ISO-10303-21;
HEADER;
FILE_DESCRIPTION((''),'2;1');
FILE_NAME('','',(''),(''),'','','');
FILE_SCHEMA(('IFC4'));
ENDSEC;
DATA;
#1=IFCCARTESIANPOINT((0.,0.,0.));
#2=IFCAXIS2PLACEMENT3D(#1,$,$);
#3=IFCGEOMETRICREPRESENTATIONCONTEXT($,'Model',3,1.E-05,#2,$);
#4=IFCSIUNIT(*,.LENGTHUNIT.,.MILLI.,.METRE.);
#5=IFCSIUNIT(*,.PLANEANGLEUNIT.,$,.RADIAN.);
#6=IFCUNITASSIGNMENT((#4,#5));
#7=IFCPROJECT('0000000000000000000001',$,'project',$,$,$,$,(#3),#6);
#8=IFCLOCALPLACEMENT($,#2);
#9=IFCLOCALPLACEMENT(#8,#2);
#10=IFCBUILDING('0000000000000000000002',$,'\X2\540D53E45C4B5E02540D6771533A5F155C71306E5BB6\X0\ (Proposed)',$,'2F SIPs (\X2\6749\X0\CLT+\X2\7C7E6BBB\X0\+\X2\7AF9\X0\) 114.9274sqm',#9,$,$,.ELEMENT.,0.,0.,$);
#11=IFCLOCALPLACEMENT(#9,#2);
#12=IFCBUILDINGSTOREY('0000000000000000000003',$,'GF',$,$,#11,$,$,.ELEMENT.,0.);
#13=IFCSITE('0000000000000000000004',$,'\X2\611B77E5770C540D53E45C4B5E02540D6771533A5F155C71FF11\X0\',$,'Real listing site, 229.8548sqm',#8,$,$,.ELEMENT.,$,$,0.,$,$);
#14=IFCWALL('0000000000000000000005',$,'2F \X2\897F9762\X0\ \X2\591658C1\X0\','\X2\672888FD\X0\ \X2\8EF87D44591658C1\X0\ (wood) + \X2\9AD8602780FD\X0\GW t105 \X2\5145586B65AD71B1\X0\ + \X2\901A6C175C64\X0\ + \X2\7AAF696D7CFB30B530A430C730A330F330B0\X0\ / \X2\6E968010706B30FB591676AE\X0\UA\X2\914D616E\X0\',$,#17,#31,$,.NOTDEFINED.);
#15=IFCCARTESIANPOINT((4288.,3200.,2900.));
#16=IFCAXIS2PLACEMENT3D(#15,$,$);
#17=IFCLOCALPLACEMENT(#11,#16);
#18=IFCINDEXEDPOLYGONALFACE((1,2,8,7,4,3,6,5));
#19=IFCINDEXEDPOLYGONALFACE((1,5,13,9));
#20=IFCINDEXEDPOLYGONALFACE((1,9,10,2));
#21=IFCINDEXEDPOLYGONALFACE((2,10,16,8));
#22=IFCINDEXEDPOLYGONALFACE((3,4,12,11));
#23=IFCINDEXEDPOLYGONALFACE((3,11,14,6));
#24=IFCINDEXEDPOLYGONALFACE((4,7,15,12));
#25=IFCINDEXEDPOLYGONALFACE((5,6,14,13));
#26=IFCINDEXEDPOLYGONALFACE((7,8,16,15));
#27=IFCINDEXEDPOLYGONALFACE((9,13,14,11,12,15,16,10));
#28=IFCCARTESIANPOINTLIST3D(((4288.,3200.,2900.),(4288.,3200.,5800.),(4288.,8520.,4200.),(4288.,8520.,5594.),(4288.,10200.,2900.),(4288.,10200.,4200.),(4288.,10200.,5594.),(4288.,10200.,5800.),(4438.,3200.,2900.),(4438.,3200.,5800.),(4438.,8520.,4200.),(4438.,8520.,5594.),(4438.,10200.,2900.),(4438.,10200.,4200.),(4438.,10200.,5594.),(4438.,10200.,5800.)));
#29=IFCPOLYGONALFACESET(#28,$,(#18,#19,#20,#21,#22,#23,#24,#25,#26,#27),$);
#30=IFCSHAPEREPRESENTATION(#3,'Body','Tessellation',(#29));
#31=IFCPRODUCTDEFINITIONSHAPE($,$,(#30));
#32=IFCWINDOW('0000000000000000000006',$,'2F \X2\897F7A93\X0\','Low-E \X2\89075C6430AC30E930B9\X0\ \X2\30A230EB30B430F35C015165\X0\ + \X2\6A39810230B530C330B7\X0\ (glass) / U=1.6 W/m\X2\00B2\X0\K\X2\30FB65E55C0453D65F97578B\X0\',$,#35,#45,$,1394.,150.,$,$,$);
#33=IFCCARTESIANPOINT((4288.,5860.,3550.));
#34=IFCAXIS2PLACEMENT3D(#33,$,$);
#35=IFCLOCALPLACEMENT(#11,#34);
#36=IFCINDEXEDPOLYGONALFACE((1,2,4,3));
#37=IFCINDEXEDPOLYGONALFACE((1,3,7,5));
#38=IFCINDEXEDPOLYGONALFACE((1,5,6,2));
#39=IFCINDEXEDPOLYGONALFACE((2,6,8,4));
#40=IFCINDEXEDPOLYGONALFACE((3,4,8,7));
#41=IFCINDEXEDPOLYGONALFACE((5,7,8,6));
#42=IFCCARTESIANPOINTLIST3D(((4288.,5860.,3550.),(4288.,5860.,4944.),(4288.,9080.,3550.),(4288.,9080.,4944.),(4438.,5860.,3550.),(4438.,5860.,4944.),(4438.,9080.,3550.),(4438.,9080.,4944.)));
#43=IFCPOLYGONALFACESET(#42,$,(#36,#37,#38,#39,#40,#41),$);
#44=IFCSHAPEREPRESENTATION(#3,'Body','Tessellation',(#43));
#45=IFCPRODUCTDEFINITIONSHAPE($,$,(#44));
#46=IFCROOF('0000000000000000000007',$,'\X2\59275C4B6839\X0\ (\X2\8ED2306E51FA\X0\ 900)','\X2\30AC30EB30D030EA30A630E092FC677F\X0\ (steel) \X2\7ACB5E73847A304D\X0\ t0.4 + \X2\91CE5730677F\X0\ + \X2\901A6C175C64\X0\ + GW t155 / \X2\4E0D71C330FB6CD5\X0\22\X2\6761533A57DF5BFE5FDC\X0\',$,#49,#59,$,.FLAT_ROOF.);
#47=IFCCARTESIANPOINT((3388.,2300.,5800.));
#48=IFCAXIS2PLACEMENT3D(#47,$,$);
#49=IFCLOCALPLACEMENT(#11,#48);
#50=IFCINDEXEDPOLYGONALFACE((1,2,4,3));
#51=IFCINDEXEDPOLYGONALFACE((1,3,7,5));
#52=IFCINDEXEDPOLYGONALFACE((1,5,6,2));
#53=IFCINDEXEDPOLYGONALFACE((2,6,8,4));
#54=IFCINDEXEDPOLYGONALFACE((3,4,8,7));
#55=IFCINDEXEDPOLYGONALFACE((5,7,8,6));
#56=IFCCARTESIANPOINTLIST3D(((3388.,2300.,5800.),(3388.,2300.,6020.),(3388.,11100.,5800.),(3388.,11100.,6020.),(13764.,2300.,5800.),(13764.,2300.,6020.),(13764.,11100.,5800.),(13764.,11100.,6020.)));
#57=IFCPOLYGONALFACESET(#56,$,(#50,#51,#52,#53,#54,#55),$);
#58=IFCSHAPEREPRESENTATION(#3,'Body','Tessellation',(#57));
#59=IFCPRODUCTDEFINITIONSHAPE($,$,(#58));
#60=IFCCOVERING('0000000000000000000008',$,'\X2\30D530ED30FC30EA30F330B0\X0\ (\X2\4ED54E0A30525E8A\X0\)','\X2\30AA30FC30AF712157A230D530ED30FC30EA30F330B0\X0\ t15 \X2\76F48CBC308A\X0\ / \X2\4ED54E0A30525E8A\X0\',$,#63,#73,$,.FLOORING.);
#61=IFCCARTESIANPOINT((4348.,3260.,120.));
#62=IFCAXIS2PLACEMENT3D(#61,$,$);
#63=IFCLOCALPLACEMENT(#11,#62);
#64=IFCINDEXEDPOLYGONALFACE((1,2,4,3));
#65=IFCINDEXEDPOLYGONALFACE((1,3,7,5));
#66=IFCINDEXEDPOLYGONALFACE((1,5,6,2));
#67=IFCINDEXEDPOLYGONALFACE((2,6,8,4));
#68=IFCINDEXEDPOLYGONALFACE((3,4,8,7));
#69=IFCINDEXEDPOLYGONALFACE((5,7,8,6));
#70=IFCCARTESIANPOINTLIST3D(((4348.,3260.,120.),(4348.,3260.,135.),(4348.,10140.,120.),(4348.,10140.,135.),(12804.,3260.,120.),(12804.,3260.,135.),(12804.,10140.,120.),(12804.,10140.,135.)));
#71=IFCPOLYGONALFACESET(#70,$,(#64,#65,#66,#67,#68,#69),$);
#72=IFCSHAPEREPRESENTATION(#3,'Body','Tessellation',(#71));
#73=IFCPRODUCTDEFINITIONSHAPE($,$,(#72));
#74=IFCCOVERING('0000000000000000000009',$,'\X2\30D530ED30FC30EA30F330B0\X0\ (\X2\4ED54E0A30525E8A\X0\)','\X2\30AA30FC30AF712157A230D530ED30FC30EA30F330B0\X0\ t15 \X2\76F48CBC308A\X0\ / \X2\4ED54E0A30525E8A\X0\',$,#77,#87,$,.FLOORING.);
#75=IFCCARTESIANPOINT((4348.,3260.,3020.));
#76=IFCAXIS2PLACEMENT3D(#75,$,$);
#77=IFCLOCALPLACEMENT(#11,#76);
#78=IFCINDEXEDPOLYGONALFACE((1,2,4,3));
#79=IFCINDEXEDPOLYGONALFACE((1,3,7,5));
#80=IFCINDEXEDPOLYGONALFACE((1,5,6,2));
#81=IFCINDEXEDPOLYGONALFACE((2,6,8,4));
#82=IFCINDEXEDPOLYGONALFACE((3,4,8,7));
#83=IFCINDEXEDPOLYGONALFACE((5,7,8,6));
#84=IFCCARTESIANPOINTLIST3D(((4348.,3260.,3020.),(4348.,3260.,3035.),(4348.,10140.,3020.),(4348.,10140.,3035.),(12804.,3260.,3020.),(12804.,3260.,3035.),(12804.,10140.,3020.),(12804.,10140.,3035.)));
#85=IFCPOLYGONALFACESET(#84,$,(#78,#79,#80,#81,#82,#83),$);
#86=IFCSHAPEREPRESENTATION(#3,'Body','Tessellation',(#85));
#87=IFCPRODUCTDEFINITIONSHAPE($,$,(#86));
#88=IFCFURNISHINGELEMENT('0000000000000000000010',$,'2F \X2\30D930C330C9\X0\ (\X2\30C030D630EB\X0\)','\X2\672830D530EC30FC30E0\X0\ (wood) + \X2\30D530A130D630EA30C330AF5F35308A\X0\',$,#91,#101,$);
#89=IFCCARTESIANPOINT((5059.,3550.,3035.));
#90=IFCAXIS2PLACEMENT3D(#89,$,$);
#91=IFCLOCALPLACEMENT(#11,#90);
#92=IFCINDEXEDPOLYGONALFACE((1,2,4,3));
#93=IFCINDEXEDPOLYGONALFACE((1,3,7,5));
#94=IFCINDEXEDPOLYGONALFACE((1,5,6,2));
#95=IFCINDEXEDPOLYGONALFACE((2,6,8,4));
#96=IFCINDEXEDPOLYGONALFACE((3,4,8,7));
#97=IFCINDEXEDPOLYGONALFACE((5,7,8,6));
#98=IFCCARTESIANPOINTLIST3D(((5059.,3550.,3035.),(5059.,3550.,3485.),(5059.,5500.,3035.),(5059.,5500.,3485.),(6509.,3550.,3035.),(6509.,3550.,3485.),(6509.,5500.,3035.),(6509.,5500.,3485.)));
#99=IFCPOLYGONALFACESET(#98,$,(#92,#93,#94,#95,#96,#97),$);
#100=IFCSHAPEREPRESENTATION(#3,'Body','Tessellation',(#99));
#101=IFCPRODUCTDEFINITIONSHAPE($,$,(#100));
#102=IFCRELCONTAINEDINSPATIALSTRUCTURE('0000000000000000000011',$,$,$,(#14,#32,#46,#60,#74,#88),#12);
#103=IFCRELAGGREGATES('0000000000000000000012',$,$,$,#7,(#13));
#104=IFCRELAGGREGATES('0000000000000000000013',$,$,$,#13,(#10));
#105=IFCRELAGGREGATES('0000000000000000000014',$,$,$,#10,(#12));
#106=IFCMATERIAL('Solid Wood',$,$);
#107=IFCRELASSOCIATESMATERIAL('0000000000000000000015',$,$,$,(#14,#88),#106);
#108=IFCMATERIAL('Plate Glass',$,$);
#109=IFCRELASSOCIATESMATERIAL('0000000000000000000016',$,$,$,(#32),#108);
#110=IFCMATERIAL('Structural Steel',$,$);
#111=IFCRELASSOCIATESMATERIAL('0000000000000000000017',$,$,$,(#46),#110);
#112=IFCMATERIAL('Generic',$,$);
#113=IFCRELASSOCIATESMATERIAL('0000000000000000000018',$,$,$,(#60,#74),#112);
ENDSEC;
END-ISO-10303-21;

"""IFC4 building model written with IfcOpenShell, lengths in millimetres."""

from ifc_helpers import new_model, si_unit, frame, frame_2d, origin, place, context, project, spatial, rectangle, extrude, material, element, fill, save


model = new_model("IFC4")

# Units and contexts
model_context = context("Model", 3, precision=1e-05, world=origin())
ifc_project = project(units=[si_unit("LENGTHUNIT", "METRE", prefix="MILLI"), si_unit("PLANEANGLEUNIT", "RADIAN")], contexts=[model_context])

# Site, building, storey
site_placement = place(None, origin())
site = spatial("IfcSite", under=ifc_project, at=site_placement, Name="愛知県名古屋市名東区引山１", ObjectType="Real listing site, 229.8548sqm", CompositionType="ELEMENT", RefElevation=0.0)
building_placement = place(site_placement, origin())
building = spatial("IfcBuilding", under=site, at=building_placement, Name="名古屋市名東区引山の家 (Proposed)", ObjectType="2F SIPs (杉CLT+籾殻+竹) 114.9274sqm", CompositionType="ELEMENT", ElevationOfRefHeight=0.0, ElevationOfTerrain=0.0)
storey_placement = place(building_placement, origin())
storey = spatial("IfcBuildingStorey", under=building, at=storey_placement, Name="GF", CompositionType="ELEMENT", Elevation=0.0)

# Shared definitions
ifc_material_1 = material(Name="Solid Wood")

# Shared definitions
ifc_material_2 = material(Name="Plate Glass")

# Wall, opening, window
wall_1_placement = place(storey_placement, frame((4288.0, 3200.0, 2900.0)))
wall_1 = element("IfcWall", 1, at=wall_1_placement, inside=storey, material=ifc_material_1, Name="2F 西面 外壁", Description="木製 軸組外壁 (wood) + 高性能GW t105 充填断熱 + 通気層 + 窯業系サイディング / 準耐火・外皮UA配慮", PredefinedType="NOTDEFINED", context=model_context, shape_type="SweptSolid", body=[
    extrude(rectangle(XDim=150.0, YDim=7000.0, at=frame_2d((75.0, 3500.0))), frame((4288.0, 3200.0, 2900.0)), (0.0, 0.0, 1.0), 2900.0),
])
opening_1_placement = place(storey_placement, frame((4288.0, 5860.0, 3550.0)))
opening_1 = element("IfcOpeningElement", 2, at=opening_1_placement, cuts=wall_1, PredefinedType="NOTDEFINED", context=model_context, shape_type="SweptSolid", body=[
    extrude(rectangle(XDim=150.0, YDim=3220.0, at=frame_2d((75.0, 1610.0))), frame((4288.0, 5860.0, 3550.0)), (0.0, 0.0, 1.0), 1394.0),
])
window_1_placement = place(storey_placement, frame((4288.0, 5860.0, 3550.0)))
window_1 = element("IfcWindow", 3, at=window_1_placement, inside=storey, material=ifc_material_2, Name="2F 西窓", Description="Low-E 複層ガラス アルゴン封入 + 樹脂サッシ (glass) / U=1.6 W/m²K・日射取得型", OverallHeight=1394.0, OverallWidth=150.0, context=model_context, shape_type="SweptSolid", body=[
    extrude(rectangle(XDim=150.0, YDim=3220.0, at=frame_2d((75.0, 1610.0))), frame((4288.0, 5860.0, 3550.0)), (0.0, 0.0, 1.0), 1394.0),
])
fill(opening_1, window_1)

# Roof
ifc_material_3 = material(Name="Structural Steel")
roof_placement = place(storey_placement, frame((3388.0, 2300.0, 5800.0)))
element("IfcRoof", 4, at=roof_placement, inside=storey, material=ifc_material_3, Name="大屋根 (軒の出 900)", Description="ガルバリウム鋼板 (steel) 立平葺き t0.4 + 野地板 + 通気層 + GW t155 / 不燃・法22条区域対応", PredefinedType="FLAT_ROOF", context=model_context, shape_type="SweptSolid", body=[
    extrude(rectangle(XDim=10376.0, YDim=8800.0, at=frame_2d((5188.0, 4400.0))), frame((3388.0, 2300.0, 5800.0)), (0.0, 0.0, 1.0), 220.0),
])

# Coverings
ifc_material_4 = material(Name="Generic")
covering_1_placement = place(storey_placement, frame((4348.0, 3260.0, 120.0)))
element("IfcCovering", 5, at=covering_1_placement, inside=storey, material=ifc_material_4, Name="フローリング (仕上げ床)", Description="オーク無垢フローリング t15 直貼り / 仕上げ床", PredefinedType="FLOORING", context=model_context, shape_type="SweptSolid", body=[
    extrude(rectangle(XDim=8456.0, YDim=6880.0, at=frame_2d((4228.0, 3440.0))), frame((4348.0, 3260.0, 120.0)), (0.0, 0.0, 1.0), 15.0),
])
covering_2_placement = place(storey_placement, frame((4348.0, 3260.0, 3020.0)))
element("IfcCovering", 6, at=covering_2_placement, inside=storey, material=ifc_material_4, Name="フローリング (仕上げ床)", Description="オーク無垢フローリング t15 直貼り / 仕上げ床", PredefinedType="FLOORING", context=model_context, shape_type="SweptSolid", body=[
    extrude(rectangle(XDim=8456.0, YDim=6880.0, at=frame_2d((4228.0, 3440.0))), frame((4348.0, 3260.0, 3020.0)), (0.0, 0.0, 1.0), 15.0),
])

# Furnishing element
furnishing_placement = place(storey_placement, frame((5059.0, 3550.0, 3035.0)))
element("IfcFurnishingElement", 7, at=furnishing_placement, inside=storey, material=ifc_material_1, Name="2F ベッド (ダブル)", Description="木フレーム (wood) + ファブリック張り", context=model_context, shape_type="SweptSolid", body=[
    extrude(rectangle(XDim=1450.0, YDim=1950.0, at=frame_2d((725.0, 975.0))), frame((5059.0, 3550.0, 3035.0)), (0.0, 0.0, 1.0), 450.0),
])

save(model, "model.ifc")
